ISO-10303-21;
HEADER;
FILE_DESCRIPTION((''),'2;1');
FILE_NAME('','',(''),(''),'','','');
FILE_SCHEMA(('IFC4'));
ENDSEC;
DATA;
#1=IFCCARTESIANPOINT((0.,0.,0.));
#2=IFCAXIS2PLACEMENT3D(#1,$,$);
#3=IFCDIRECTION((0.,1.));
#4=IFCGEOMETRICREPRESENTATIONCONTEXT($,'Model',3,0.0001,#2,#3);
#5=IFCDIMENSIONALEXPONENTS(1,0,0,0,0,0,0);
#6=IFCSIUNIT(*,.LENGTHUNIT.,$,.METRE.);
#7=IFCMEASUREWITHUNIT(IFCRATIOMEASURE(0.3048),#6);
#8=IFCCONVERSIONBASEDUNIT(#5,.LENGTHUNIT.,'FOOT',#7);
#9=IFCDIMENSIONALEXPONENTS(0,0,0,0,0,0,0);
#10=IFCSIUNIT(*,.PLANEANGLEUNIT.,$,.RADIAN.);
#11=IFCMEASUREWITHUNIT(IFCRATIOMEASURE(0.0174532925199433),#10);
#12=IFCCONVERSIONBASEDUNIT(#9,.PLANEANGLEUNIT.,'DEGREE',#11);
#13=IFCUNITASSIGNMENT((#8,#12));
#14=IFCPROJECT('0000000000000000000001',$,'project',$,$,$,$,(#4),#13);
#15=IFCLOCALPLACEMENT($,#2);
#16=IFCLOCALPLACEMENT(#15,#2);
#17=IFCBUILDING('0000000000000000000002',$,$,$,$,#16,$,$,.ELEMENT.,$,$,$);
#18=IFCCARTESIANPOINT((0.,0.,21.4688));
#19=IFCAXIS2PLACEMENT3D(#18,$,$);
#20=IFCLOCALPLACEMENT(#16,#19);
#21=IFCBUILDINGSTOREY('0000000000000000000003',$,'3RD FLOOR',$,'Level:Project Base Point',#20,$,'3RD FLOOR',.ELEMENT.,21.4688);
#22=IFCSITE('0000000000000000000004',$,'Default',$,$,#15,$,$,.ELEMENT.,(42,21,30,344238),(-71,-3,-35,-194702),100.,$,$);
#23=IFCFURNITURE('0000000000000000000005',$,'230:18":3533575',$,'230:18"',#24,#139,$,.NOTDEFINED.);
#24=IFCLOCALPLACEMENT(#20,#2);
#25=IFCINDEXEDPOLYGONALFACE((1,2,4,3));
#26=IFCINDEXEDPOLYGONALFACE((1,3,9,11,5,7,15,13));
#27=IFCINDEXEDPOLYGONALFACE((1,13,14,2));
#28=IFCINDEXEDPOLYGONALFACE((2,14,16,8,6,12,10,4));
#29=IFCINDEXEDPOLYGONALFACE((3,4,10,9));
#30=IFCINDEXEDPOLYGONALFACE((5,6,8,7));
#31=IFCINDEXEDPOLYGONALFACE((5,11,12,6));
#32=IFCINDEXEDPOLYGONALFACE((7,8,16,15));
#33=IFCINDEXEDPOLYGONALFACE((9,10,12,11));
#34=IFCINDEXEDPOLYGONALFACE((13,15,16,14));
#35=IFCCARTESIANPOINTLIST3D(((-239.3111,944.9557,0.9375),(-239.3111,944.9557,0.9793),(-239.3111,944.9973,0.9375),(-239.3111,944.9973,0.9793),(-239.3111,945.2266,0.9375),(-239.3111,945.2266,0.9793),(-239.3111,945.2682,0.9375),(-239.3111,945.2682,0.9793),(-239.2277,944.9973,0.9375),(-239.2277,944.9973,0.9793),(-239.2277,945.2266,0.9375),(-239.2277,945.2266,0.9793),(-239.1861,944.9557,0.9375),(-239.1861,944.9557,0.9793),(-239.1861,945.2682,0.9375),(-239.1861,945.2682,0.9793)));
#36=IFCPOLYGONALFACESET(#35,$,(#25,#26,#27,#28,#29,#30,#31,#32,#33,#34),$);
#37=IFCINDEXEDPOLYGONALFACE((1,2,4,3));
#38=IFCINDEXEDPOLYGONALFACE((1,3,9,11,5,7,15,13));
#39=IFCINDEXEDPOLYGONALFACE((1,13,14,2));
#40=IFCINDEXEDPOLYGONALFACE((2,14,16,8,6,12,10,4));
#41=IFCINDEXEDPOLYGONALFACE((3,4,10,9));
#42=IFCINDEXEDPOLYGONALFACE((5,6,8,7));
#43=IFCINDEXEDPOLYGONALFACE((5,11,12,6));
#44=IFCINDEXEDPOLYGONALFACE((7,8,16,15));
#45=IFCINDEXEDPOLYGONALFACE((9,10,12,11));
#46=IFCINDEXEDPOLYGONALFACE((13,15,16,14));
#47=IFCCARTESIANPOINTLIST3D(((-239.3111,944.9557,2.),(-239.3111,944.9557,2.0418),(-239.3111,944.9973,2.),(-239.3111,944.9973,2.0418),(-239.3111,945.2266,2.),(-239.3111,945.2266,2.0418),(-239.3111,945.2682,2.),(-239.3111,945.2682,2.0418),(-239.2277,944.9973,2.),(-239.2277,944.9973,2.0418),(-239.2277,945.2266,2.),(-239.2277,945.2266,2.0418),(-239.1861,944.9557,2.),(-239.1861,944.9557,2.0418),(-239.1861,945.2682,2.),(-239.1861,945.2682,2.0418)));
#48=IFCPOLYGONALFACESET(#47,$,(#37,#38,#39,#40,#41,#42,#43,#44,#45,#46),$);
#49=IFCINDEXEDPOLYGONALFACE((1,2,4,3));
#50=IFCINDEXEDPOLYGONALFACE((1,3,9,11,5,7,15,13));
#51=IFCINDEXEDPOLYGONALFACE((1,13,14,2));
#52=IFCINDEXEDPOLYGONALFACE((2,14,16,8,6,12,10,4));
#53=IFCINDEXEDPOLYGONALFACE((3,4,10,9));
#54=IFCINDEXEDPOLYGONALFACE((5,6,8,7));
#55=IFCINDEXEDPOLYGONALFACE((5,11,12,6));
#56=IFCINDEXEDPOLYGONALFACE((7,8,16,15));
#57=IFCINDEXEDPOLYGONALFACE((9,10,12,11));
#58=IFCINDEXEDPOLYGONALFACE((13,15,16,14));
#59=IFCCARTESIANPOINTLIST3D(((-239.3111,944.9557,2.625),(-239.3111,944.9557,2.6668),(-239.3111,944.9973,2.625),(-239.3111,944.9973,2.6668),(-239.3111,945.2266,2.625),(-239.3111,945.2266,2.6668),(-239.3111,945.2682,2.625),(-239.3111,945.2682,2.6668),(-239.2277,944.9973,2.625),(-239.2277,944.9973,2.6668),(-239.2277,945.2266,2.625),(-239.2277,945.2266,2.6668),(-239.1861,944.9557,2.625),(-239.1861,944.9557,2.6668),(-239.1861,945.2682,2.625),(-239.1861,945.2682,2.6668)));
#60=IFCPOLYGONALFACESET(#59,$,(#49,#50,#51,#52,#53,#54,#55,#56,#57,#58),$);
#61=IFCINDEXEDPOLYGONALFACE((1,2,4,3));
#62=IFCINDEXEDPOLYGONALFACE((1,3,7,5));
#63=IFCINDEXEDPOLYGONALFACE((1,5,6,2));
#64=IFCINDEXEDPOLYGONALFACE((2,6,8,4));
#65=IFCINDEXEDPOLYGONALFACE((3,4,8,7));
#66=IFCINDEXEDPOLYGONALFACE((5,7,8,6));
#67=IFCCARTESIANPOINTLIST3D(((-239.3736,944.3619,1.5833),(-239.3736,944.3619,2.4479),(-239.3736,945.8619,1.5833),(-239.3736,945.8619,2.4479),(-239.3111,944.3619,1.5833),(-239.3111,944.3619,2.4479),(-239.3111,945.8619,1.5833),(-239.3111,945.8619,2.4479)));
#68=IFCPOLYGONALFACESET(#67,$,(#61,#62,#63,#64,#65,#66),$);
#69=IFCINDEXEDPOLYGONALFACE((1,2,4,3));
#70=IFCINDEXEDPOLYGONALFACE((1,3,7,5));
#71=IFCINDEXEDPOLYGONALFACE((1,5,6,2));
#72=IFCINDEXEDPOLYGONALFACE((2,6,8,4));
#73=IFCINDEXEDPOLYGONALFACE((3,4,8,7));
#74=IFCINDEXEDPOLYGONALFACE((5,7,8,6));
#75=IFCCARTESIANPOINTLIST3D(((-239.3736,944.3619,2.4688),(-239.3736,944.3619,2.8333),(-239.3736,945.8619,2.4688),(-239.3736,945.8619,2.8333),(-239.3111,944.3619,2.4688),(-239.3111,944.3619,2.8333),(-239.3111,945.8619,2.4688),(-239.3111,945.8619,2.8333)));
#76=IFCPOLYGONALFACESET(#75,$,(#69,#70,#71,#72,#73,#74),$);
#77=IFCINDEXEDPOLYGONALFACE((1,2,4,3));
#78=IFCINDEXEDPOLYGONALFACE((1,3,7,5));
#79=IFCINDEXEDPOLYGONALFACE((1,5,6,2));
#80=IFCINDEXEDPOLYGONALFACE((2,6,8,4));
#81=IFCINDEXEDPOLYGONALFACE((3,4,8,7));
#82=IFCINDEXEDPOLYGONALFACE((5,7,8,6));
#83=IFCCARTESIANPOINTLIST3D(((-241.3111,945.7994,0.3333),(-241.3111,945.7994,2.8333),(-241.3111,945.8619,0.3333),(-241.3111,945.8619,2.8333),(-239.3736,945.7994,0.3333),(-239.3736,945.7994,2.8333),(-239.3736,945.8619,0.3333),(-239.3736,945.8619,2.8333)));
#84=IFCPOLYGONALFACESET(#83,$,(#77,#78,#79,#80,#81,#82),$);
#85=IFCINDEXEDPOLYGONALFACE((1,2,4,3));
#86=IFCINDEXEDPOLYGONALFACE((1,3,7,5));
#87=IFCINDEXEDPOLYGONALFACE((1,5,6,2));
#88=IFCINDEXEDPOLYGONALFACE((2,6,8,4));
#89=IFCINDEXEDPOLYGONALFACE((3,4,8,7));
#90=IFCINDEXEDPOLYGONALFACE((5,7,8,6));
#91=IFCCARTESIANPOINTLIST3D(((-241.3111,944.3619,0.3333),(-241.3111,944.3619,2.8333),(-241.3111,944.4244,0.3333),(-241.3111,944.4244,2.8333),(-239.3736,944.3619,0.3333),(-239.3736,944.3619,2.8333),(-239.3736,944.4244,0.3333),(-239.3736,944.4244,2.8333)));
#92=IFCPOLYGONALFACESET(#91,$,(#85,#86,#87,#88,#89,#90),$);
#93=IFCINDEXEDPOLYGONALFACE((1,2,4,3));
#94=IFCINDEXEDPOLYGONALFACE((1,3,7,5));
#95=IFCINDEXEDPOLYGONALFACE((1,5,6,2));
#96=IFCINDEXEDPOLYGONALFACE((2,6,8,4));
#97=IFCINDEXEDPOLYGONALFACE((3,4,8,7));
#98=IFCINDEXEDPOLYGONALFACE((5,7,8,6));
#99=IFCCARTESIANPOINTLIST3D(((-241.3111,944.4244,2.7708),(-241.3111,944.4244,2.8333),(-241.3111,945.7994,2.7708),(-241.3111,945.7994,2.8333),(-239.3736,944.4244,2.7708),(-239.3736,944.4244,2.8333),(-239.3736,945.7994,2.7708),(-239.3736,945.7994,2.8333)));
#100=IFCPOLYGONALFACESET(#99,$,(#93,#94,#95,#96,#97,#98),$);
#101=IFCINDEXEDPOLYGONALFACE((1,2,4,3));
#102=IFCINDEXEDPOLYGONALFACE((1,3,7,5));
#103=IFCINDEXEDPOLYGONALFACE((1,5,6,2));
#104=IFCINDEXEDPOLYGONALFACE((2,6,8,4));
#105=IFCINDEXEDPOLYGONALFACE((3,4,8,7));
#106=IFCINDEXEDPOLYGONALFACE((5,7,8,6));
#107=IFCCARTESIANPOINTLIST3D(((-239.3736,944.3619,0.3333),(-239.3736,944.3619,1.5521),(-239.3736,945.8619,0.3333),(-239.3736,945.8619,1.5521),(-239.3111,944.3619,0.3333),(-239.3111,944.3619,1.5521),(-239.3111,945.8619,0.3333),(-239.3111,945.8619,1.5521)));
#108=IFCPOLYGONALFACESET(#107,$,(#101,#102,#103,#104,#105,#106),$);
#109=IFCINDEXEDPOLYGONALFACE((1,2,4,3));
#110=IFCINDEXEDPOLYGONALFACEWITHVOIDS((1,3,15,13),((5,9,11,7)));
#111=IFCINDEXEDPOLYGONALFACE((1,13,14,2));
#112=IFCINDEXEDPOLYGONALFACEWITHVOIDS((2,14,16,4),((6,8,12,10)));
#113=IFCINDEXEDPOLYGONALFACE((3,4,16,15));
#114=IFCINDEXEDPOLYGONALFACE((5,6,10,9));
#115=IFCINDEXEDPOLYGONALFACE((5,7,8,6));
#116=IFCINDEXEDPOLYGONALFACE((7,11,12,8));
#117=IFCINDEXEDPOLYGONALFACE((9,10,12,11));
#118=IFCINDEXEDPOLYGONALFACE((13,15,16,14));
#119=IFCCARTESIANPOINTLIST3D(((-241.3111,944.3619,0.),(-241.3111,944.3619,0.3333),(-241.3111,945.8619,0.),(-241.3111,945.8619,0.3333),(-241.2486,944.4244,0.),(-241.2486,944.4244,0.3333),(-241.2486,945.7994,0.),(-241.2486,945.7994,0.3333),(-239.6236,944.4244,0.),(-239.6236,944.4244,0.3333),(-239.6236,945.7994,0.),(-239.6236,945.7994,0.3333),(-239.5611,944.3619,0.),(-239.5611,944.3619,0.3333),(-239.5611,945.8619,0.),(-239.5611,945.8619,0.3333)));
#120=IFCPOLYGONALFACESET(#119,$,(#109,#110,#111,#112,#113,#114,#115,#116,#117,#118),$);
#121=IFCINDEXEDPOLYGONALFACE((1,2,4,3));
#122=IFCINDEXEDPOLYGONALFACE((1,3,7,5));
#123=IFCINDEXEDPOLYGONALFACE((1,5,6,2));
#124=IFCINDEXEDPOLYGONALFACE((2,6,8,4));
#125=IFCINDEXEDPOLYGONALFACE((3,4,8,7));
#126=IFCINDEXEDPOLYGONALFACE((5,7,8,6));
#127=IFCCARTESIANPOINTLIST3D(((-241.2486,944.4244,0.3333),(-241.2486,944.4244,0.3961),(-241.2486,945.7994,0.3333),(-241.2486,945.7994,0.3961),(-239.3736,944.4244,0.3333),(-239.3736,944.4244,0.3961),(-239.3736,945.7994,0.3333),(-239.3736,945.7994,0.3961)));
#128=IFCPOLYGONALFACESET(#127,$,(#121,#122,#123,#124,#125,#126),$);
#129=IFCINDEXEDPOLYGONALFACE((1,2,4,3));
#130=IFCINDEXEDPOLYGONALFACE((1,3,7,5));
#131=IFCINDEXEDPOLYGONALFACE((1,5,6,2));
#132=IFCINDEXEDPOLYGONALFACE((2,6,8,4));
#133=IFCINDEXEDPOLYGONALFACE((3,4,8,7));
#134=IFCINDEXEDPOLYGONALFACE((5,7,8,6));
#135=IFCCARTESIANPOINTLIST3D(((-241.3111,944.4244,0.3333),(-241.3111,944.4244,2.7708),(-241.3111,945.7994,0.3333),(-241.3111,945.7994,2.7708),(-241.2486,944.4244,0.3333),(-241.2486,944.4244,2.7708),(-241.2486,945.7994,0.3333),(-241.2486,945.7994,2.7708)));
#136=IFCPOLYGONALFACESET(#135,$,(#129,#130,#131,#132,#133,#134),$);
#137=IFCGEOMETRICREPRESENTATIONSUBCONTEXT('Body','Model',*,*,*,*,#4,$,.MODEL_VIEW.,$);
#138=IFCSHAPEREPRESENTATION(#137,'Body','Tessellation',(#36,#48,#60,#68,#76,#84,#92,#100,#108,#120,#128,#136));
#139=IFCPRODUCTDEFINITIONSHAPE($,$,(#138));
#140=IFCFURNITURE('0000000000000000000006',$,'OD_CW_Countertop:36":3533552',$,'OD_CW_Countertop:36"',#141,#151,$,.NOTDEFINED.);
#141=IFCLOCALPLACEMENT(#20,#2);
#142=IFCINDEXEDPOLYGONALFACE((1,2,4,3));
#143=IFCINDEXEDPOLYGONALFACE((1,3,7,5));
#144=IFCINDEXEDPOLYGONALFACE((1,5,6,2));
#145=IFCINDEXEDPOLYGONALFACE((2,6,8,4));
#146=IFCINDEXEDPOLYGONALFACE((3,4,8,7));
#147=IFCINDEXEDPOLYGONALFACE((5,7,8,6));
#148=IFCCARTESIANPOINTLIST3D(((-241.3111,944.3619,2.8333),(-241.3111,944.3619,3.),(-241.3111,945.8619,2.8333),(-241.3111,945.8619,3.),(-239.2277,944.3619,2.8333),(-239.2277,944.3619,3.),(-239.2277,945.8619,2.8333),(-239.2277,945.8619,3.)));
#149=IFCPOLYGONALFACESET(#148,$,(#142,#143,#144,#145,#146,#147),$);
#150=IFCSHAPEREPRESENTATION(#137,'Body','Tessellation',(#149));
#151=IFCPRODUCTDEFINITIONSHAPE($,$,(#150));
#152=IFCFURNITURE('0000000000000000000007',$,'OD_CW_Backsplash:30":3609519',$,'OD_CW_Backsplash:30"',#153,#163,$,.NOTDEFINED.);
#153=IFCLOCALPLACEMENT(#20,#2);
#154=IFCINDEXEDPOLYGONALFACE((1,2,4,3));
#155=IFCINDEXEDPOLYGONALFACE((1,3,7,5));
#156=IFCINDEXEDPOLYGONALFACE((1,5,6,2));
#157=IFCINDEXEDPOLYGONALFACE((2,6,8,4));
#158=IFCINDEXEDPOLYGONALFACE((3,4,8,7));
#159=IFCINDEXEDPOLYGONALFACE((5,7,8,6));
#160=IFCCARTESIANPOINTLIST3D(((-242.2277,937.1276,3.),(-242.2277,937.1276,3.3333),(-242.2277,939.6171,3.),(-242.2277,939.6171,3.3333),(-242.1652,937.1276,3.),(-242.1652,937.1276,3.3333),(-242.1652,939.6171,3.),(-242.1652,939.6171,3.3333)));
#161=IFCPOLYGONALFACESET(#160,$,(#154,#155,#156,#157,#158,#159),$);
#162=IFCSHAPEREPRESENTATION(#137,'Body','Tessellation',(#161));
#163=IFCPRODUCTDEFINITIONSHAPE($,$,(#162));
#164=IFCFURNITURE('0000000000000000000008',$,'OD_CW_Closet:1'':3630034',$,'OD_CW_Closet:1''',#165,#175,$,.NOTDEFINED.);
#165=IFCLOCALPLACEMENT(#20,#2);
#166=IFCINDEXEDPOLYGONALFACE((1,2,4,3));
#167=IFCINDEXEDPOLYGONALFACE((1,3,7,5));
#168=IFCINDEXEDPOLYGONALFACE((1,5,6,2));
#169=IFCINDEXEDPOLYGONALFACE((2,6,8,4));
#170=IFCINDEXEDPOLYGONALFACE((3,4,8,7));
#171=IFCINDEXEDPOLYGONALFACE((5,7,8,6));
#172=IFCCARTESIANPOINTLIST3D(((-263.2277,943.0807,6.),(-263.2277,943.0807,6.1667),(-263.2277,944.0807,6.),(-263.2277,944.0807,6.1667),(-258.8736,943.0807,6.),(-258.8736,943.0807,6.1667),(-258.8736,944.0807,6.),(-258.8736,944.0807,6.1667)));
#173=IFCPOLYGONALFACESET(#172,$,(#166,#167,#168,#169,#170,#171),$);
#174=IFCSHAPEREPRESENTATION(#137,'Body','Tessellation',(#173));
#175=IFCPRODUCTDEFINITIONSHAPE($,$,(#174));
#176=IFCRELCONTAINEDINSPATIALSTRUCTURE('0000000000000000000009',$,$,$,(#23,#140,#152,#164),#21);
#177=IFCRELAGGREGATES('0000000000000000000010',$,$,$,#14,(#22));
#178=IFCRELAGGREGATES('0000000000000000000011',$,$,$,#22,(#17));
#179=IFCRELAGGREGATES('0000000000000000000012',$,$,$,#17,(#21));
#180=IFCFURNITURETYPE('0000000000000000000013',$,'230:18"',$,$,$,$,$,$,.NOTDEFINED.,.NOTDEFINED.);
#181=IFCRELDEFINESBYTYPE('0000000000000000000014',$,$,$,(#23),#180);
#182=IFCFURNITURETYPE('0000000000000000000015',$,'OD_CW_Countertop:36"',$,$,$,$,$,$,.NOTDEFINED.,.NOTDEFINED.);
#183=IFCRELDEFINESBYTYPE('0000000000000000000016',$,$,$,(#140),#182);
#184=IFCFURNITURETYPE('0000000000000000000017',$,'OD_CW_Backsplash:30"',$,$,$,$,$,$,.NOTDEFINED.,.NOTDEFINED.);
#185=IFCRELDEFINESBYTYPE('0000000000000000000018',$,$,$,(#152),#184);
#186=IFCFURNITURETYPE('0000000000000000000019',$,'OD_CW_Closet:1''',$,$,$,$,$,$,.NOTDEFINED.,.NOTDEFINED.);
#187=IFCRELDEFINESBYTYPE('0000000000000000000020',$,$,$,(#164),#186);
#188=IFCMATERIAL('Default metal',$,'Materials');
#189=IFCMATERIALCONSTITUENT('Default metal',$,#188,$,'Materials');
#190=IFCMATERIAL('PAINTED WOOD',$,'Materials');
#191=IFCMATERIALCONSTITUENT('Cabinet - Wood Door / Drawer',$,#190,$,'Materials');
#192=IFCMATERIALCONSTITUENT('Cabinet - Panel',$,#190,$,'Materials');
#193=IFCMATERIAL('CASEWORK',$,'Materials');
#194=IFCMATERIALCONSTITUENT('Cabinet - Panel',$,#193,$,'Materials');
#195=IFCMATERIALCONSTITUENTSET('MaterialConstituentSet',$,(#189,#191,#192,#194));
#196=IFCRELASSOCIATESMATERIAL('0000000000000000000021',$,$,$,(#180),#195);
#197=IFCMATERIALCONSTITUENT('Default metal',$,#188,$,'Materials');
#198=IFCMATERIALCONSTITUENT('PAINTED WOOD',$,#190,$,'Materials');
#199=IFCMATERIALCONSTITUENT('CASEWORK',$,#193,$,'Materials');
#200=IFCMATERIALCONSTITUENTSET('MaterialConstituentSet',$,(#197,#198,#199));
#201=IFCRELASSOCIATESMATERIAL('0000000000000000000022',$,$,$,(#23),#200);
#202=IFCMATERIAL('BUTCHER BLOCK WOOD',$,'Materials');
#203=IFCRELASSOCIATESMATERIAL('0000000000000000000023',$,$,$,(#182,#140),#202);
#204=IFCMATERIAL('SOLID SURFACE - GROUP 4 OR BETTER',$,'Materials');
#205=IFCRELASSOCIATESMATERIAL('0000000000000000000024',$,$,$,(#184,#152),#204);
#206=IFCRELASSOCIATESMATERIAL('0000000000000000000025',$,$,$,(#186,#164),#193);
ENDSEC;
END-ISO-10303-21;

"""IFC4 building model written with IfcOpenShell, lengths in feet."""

from ifc_helpers import new_model, entity, si_unit, converted_unit, direction, frame, frame_2d, origin, origin_2d_with_axis, place, context, subcontext, project, spatial, polyline, rectangle, outline, extrude, source, transform, mapped, material, constituent, constituent_set, type_object, type_shapes, element, save


model = new_model("IFC4")

# Units and contexts
model_context = context("Model", 3, precision=0.0001, world=origin(), true_north=direction((0.0, 1.0)))
body_context = subcontext(model_context, "Body", "Model", "MODEL_VIEW")
ifc_project = project(units=[converted_unit("LENGTHUNIT", "FOOT", entity("IfcRatioMeasure", 0.3048), si_unit("LENGTHUNIT", "METRE"), dimensions=[1, 0, 0, 0, 0, 0, 0]), converted_unit("PLANEANGLEUNIT", "DEGREE", entity("IfcRatioMeasure", 0.0174532925199433), si_unit("PLANEANGLEUNIT", "RADIAN"), dimensions=[0, 0, 0, 0, 0, 0, 0])], contexts=[model_context])

# Site, building, storey
site_placement = place(None, origin())
site = spatial("IfcSite", under=ifc_project, at=site_placement, Name="Default", CompositionType="ELEMENT", RefLatitude=(42, 21, 30, 344238), RefLongitude=(-71, -3, -35, -194702), RefElevation=100.0)
building_placement = place(site_placement, origin())
building = spatial("IfcBuilding", under=site, at=building_placement, CompositionType="ELEMENT")
storey_placement = place(building_placement, frame((0.0, 0.0, 21.4688)))
storey = spatial("IfcBuildingStorey", under=building, at=storey_placement, Name="3RD FLOOR", ObjectType="Level:Project Base Point", LongName="3RD FLOOR", CompositionType="ELEMENT", Elevation=21.4688)

# Furniture
ifc_material_1 = material(Name="CASEWORK", Category="Materials")
ifc_material_2 = material(Name="PAINTED WOOD", Category="Materials")
ifc_material_3 = material(Name="SOLID SURFACE - GROUP 4 OR BETTER", Category="Materials")
ifc_material_4 = material(Name="BUTCHER BLOCK WOOD", Category="Materials")
ifc_material_5 = material(Name="Default metal", Category="Materials")
ifc_constituent_1 = constituent(ifc_material_5, Name="Default metal", Category="Materials")
ifc_constituent_2 = constituent(ifc_material_2, Name="PAINTED WOOD", Category="Materials")
ifc_constituent_3 = constituent(ifc_material_1, Name="CASEWORK", Category="Materials")
ifc_constituent_set_1 = constituent_set(constituents=[ifc_constituent_1, ifc_constituent_2, ifc_constituent_3], Name="MaterialConstituentSet")
ifc_constituent_4 = constituent(ifc_material_5, Name="Default metal", Category="Materials")
ifc_constituent_5 = constituent(ifc_material_2, Name="Cabinet - Wood Door / Drawer", Category="Materials")
ifc_constituent_6 = constituent(ifc_material_2, Name="Cabinet - Panel", Category="Materials")
ifc_constituent_7 = constituent(ifc_material_1, Name="Cabinet - Panel", Category="Materials")
ifc_constituent_set_2 = constituent_set(constituents=[ifc_constituent_4, ifc_constituent_5, ifc_constituent_6, ifc_constituent_7], Name="MaterialConstituentSet")
furniture_type_1 = type_object("IfcFurnitureType", Name="230:18\"", AssemblyPlace="NOTDEFINED", PredefinedType="NOTDEFINED", material=ifc_constituent_set_2)
shared_shape_1 = source(origin(), body_context, "Body", "SweptSolid", [
    extrude(outline(polyline([(-0.1562, -0.0521), (-0.1146, -0.0521), (-0.1146, 0.0313), (0.1146, 0.0313), (0.1146, -0.0521), (0.1562, -0.0521), (0.1562, 0.0729), (-0.1562, 0.0729), (-0.1562, -0.0521)])), frame((0.0615, 2.0521, 0.9375)), (0.0, 0.0, 1.0), 0.0418),
    extrude(outline(polyline([(-0.1562, -0.0521), (-0.1146, -0.0521), (-0.1146, 0.0313), (0.1146, 0.0313), (0.1146, -0.0521), (0.1562, -0.0521), (0.1562, 0.0729), (-0.1562, 0.0729), (-0.1562, -0.0521)])), frame((0.0615, 2.0521, 2.0)), (0.0, 0.0, 1.0), 0.0418),
    extrude(outline(polyline([(-0.1562, -0.0521), (-0.1146, -0.0521), (-0.1146, 0.0313), (0.1146, 0.0313), (0.1146, -0.0521), (0.1562, -0.0521), (0.1562, 0.0729), (-0.1562, 0.0729), (-0.1562, -0.0521)])), frame((0.0615, 2.0521, 2.625)), (0.0, 0.0, 1.0), 0.0418),
    extrude(rectangle(XDim=1.5, YDim=0.0625, at=frame_2d((0.0, 0.0), x_axis=(1.0, 0.0))), frame((0.0615, 1.9688, 1.5833), z_axis=(0.0, 0.0, 1.0), x_axis=(-1.0, 0.0, 0.0)), (0.0, 0.0, 1.0), 0.8646),
    extrude(rectangle(XDim=1.5, YDim=0.0625, at=frame_2d((0.0, 0.0), x_axis=(1.0, 0.0))), frame((0.0615, 1.9688, 2.4688), z_axis=(0.0, 0.0, 1.0), x_axis=(-1.0, 0.0, 0.0)), (0.0, 0.0, 1.0), 0.3646),
    extrude(rectangle(XDim=1.9375, YDim=0.0625, at=frame_2d((0.0, 0.0), x_axis=(1.0, 0.0))), frame((-0.6573, 0.9687, 0.3333), z_axis=(0.0, 0.0, 1.0), x_axis=(0.0, -1.0, 0.0)), (0.0, 0.0, 1.0), 2.5),
    extrude(rectangle(XDim=1.9375, YDim=0.0625, at=frame_2d((0.0, 0.0), x_axis=(1.0, 0.0))), frame((0.7802, 0.9687, 0.3333), z_axis=(0.0, 0.0, 1.0), x_axis=(0.0, -1.0, 0.0)), (0.0, 0.0, 1.0), 2.5),
    extrude(rectangle(XDim=1.9375, YDim=1.375, at=origin_2d_with_axis()), frame((0.0615, 0.9687, 2.7708), z_axis=(0.0, 0.0, 1.0), x_axis=(0.0, 1.0, 0.0)), (0.0, 0.0, 1.0), 0.0625),
    extrude(rectangle(XDim=1.5, YDim=0.0625, at=frame_2d((0.0, 0.0), x_axis=(1.0, 0.0))), frame((0.0615, 1.9688, 0.3333), z_axis=(0.0, 0.0, 1.0), x_axis=(-1.0, 0.0, 0.0)), (0.0, 0.0, 1.0), 1.2187),
    extrude(outline(polyline([(-0.875, -0.75), (0.875, -0.75), (0.875, 0.75), (-0.875, 0.75), (-0.875, -0.75)]), holes=[polyline([(-0.8125, -0.6875), (-0.8125, 0.6875), (0.8125, 0.6875), (0.8125, -0.6875), (-0.8125, -0.6875)])]), frame((0.0615, 0.875, 0.0), z_axis=(0.0, 0.0, 1.0), x_axis=(0.0, -1.0, 0.0)), (0.0, 0.0, 1.0), 0.3333),
    extrude(rectangle(XDim=1.875, YDim=1.375, at=origin_2d_with_axis()), frame((0.0615, 1.0, 0.3333), z_axis=(0.0, 0.0, 1.0), x_axis=(0.0, 1.0, 0.0)), (0.0, 0.0, 1.0), 0.0627),
    extrude(rectangle(XDim=1.375, YDim=0.0625, at=origin_2d_with_axis()), frame((0.0615, 0.0312, 0.3333), z_axis=(0.0, 0.0, 1.0), x_axis=(-1.0, 0.0, 0.0)), (0.0, 0.0, 1.0), 2.4375),
])
type_shapes(furniture_type_1, [shared_shape_1])
furniture_1_placement = place(storey_placement, frame((-241.3111, 945.1734, 0.0), z_axis=(0.0, 0.0, 1.0), x_axis=(0.0, -1.0, 0.0)))
element("IfcFurniture", 1, at=furniture_1_placement, inside=storey, type_object=furniture_type_1, material=ifc_constituent_set_1, Name="230:18\":3533575", ObjectType="230:18\"", PredefinedType="NOTDEFINED", context=body_context, shape_type="MappedRepresentation", body=[
    mapped(shared_shape_1, transform((0.0, 0.0, 0.0), scale=1.0)),
])
furniture_type_2 = type_object("IfcFurnitureType", Name="OD_CW_Countertop:36\"", AssemblyPlace="NOTDEFINED", PredefinedType="NOTDEFINED", material=ifc_material_4)
shared_shape_2 = source(origin(), body_context, "Body", "SweptSolid", [
    extrude(rectangle(XDim=2.0833, YDim=1.5, at=origin_2d_with_axis()), frame((0.75, 1.0417, 0.0), z_axis=(0.0, 0.0, 1.0), x_axis=(0.0, -1.0, 0.0)), (0.0, 0.0, 1.0), 0.1667),
])
type_shapes(furniture_type_2, [shared_shape_2])
furniture_2_placement = place(storey_placement, frame((-239.2277, 944.3619, 2.8333), z_axis=(0.0, 0.0, 1.0), x_axis=(0.0, 1.0, 0.0)))
element("IfcFurniture", 2, at=furniture_2_placement, inside=storey, type_object=furniture_type_2, material=ifc_material_4, Name="OD_CW_Countertop:36\":3533552", ObjectType="OD_CW_Countertop:36\"", PredefinedType="NOTDEFINED", context=body_context, shape_type="MappedRepresentation", body=[
    mapped(shared_shape_2, transform((0.0, 0.0, 0.0), scale=1.0)),
])
furniture_type_3 = type_object("IfcFurnitureType", Name="OD_CW_Backsplash:30\"", AssemblyPlace="NOTDEFINED", PredefinedType="NOTDEFINED", material=ifc_material_3)
shared_shape_3 = source(origin(), body_context, "Body", "SweptSolid", [
    extrude(rectangle(XDim=2.4896, YDim=0.0625, at=frame_2d((0.0, 0.0), x_axis=(1.0, 0.0))), frame((1.2448, 0.0313, 0.0)), (0.0, 0.0, 1.0), 0.3333),
])
type_shapes(furniture_type_3, [shared_shape_3])
furniture_3_placement = place(storey_placement, frame((-242.1652, 937.1276, 3.0), z_axis=(0.0, 0.0, 1.0), x_axis=(0.0, 1.0, 0.0)))
element("IfcFurniture", 3, at=furniture_3_placement, inside=storey, type_object=furniture_type_3, material=ifc_material_3, Name="OD_CW_Backsplash:30\":3609519", ObjectType="OD_CW_Backsplash:30\"", PredefinedType="NOTDEFINED", context=body_context, shape_type="MappedRepresentation", body=[
    mapped(shared_shape_3, transform((0.0, 0.0, 0.0), scale=1.0)),
])
furniture_type_4 = type_object("IfcFurnitureType", Name="OD_CW_Closet:1'", AssemblyPlace="NOTDEFINED", PredefinedType="NOTDEFINED", material=ifc_material_1)
shared_shape_4 = source(origin(), body_context, "Body", "SweptSolid", [
    extrude(rectangle(XDim=4.3542, YDim=1.0, at=frame_2d((0.0, 0.0), x_axis=(1.0, 0.0))), frame((2.1771, 0.5, 0.0)), (0.0, 0.0, 1.0), 0.1667),
])
type_shapes(furniture_type_4, [shared_shape_4])
furniture_4_placement = place(storey_placement, frame((-263.2277, 943.0807, 6.0)))
element("IfcFurniture", 4, at=furniture_4_placement, inside=storey, type_object=furniture_type_4, material=ifc_material_1, Name="OD_CW_Closet:1':3630034", ObjectType="OD_CW_Closet:1'", PredefinedType="NOTDEFINED", context=body_context, shape_type="MappedRepresentation", body=[
    mapped(shared_shape_4, transform((0.0, 0.0, 0.0), scale=1.0)),
])

save(model, "model.ifc")
